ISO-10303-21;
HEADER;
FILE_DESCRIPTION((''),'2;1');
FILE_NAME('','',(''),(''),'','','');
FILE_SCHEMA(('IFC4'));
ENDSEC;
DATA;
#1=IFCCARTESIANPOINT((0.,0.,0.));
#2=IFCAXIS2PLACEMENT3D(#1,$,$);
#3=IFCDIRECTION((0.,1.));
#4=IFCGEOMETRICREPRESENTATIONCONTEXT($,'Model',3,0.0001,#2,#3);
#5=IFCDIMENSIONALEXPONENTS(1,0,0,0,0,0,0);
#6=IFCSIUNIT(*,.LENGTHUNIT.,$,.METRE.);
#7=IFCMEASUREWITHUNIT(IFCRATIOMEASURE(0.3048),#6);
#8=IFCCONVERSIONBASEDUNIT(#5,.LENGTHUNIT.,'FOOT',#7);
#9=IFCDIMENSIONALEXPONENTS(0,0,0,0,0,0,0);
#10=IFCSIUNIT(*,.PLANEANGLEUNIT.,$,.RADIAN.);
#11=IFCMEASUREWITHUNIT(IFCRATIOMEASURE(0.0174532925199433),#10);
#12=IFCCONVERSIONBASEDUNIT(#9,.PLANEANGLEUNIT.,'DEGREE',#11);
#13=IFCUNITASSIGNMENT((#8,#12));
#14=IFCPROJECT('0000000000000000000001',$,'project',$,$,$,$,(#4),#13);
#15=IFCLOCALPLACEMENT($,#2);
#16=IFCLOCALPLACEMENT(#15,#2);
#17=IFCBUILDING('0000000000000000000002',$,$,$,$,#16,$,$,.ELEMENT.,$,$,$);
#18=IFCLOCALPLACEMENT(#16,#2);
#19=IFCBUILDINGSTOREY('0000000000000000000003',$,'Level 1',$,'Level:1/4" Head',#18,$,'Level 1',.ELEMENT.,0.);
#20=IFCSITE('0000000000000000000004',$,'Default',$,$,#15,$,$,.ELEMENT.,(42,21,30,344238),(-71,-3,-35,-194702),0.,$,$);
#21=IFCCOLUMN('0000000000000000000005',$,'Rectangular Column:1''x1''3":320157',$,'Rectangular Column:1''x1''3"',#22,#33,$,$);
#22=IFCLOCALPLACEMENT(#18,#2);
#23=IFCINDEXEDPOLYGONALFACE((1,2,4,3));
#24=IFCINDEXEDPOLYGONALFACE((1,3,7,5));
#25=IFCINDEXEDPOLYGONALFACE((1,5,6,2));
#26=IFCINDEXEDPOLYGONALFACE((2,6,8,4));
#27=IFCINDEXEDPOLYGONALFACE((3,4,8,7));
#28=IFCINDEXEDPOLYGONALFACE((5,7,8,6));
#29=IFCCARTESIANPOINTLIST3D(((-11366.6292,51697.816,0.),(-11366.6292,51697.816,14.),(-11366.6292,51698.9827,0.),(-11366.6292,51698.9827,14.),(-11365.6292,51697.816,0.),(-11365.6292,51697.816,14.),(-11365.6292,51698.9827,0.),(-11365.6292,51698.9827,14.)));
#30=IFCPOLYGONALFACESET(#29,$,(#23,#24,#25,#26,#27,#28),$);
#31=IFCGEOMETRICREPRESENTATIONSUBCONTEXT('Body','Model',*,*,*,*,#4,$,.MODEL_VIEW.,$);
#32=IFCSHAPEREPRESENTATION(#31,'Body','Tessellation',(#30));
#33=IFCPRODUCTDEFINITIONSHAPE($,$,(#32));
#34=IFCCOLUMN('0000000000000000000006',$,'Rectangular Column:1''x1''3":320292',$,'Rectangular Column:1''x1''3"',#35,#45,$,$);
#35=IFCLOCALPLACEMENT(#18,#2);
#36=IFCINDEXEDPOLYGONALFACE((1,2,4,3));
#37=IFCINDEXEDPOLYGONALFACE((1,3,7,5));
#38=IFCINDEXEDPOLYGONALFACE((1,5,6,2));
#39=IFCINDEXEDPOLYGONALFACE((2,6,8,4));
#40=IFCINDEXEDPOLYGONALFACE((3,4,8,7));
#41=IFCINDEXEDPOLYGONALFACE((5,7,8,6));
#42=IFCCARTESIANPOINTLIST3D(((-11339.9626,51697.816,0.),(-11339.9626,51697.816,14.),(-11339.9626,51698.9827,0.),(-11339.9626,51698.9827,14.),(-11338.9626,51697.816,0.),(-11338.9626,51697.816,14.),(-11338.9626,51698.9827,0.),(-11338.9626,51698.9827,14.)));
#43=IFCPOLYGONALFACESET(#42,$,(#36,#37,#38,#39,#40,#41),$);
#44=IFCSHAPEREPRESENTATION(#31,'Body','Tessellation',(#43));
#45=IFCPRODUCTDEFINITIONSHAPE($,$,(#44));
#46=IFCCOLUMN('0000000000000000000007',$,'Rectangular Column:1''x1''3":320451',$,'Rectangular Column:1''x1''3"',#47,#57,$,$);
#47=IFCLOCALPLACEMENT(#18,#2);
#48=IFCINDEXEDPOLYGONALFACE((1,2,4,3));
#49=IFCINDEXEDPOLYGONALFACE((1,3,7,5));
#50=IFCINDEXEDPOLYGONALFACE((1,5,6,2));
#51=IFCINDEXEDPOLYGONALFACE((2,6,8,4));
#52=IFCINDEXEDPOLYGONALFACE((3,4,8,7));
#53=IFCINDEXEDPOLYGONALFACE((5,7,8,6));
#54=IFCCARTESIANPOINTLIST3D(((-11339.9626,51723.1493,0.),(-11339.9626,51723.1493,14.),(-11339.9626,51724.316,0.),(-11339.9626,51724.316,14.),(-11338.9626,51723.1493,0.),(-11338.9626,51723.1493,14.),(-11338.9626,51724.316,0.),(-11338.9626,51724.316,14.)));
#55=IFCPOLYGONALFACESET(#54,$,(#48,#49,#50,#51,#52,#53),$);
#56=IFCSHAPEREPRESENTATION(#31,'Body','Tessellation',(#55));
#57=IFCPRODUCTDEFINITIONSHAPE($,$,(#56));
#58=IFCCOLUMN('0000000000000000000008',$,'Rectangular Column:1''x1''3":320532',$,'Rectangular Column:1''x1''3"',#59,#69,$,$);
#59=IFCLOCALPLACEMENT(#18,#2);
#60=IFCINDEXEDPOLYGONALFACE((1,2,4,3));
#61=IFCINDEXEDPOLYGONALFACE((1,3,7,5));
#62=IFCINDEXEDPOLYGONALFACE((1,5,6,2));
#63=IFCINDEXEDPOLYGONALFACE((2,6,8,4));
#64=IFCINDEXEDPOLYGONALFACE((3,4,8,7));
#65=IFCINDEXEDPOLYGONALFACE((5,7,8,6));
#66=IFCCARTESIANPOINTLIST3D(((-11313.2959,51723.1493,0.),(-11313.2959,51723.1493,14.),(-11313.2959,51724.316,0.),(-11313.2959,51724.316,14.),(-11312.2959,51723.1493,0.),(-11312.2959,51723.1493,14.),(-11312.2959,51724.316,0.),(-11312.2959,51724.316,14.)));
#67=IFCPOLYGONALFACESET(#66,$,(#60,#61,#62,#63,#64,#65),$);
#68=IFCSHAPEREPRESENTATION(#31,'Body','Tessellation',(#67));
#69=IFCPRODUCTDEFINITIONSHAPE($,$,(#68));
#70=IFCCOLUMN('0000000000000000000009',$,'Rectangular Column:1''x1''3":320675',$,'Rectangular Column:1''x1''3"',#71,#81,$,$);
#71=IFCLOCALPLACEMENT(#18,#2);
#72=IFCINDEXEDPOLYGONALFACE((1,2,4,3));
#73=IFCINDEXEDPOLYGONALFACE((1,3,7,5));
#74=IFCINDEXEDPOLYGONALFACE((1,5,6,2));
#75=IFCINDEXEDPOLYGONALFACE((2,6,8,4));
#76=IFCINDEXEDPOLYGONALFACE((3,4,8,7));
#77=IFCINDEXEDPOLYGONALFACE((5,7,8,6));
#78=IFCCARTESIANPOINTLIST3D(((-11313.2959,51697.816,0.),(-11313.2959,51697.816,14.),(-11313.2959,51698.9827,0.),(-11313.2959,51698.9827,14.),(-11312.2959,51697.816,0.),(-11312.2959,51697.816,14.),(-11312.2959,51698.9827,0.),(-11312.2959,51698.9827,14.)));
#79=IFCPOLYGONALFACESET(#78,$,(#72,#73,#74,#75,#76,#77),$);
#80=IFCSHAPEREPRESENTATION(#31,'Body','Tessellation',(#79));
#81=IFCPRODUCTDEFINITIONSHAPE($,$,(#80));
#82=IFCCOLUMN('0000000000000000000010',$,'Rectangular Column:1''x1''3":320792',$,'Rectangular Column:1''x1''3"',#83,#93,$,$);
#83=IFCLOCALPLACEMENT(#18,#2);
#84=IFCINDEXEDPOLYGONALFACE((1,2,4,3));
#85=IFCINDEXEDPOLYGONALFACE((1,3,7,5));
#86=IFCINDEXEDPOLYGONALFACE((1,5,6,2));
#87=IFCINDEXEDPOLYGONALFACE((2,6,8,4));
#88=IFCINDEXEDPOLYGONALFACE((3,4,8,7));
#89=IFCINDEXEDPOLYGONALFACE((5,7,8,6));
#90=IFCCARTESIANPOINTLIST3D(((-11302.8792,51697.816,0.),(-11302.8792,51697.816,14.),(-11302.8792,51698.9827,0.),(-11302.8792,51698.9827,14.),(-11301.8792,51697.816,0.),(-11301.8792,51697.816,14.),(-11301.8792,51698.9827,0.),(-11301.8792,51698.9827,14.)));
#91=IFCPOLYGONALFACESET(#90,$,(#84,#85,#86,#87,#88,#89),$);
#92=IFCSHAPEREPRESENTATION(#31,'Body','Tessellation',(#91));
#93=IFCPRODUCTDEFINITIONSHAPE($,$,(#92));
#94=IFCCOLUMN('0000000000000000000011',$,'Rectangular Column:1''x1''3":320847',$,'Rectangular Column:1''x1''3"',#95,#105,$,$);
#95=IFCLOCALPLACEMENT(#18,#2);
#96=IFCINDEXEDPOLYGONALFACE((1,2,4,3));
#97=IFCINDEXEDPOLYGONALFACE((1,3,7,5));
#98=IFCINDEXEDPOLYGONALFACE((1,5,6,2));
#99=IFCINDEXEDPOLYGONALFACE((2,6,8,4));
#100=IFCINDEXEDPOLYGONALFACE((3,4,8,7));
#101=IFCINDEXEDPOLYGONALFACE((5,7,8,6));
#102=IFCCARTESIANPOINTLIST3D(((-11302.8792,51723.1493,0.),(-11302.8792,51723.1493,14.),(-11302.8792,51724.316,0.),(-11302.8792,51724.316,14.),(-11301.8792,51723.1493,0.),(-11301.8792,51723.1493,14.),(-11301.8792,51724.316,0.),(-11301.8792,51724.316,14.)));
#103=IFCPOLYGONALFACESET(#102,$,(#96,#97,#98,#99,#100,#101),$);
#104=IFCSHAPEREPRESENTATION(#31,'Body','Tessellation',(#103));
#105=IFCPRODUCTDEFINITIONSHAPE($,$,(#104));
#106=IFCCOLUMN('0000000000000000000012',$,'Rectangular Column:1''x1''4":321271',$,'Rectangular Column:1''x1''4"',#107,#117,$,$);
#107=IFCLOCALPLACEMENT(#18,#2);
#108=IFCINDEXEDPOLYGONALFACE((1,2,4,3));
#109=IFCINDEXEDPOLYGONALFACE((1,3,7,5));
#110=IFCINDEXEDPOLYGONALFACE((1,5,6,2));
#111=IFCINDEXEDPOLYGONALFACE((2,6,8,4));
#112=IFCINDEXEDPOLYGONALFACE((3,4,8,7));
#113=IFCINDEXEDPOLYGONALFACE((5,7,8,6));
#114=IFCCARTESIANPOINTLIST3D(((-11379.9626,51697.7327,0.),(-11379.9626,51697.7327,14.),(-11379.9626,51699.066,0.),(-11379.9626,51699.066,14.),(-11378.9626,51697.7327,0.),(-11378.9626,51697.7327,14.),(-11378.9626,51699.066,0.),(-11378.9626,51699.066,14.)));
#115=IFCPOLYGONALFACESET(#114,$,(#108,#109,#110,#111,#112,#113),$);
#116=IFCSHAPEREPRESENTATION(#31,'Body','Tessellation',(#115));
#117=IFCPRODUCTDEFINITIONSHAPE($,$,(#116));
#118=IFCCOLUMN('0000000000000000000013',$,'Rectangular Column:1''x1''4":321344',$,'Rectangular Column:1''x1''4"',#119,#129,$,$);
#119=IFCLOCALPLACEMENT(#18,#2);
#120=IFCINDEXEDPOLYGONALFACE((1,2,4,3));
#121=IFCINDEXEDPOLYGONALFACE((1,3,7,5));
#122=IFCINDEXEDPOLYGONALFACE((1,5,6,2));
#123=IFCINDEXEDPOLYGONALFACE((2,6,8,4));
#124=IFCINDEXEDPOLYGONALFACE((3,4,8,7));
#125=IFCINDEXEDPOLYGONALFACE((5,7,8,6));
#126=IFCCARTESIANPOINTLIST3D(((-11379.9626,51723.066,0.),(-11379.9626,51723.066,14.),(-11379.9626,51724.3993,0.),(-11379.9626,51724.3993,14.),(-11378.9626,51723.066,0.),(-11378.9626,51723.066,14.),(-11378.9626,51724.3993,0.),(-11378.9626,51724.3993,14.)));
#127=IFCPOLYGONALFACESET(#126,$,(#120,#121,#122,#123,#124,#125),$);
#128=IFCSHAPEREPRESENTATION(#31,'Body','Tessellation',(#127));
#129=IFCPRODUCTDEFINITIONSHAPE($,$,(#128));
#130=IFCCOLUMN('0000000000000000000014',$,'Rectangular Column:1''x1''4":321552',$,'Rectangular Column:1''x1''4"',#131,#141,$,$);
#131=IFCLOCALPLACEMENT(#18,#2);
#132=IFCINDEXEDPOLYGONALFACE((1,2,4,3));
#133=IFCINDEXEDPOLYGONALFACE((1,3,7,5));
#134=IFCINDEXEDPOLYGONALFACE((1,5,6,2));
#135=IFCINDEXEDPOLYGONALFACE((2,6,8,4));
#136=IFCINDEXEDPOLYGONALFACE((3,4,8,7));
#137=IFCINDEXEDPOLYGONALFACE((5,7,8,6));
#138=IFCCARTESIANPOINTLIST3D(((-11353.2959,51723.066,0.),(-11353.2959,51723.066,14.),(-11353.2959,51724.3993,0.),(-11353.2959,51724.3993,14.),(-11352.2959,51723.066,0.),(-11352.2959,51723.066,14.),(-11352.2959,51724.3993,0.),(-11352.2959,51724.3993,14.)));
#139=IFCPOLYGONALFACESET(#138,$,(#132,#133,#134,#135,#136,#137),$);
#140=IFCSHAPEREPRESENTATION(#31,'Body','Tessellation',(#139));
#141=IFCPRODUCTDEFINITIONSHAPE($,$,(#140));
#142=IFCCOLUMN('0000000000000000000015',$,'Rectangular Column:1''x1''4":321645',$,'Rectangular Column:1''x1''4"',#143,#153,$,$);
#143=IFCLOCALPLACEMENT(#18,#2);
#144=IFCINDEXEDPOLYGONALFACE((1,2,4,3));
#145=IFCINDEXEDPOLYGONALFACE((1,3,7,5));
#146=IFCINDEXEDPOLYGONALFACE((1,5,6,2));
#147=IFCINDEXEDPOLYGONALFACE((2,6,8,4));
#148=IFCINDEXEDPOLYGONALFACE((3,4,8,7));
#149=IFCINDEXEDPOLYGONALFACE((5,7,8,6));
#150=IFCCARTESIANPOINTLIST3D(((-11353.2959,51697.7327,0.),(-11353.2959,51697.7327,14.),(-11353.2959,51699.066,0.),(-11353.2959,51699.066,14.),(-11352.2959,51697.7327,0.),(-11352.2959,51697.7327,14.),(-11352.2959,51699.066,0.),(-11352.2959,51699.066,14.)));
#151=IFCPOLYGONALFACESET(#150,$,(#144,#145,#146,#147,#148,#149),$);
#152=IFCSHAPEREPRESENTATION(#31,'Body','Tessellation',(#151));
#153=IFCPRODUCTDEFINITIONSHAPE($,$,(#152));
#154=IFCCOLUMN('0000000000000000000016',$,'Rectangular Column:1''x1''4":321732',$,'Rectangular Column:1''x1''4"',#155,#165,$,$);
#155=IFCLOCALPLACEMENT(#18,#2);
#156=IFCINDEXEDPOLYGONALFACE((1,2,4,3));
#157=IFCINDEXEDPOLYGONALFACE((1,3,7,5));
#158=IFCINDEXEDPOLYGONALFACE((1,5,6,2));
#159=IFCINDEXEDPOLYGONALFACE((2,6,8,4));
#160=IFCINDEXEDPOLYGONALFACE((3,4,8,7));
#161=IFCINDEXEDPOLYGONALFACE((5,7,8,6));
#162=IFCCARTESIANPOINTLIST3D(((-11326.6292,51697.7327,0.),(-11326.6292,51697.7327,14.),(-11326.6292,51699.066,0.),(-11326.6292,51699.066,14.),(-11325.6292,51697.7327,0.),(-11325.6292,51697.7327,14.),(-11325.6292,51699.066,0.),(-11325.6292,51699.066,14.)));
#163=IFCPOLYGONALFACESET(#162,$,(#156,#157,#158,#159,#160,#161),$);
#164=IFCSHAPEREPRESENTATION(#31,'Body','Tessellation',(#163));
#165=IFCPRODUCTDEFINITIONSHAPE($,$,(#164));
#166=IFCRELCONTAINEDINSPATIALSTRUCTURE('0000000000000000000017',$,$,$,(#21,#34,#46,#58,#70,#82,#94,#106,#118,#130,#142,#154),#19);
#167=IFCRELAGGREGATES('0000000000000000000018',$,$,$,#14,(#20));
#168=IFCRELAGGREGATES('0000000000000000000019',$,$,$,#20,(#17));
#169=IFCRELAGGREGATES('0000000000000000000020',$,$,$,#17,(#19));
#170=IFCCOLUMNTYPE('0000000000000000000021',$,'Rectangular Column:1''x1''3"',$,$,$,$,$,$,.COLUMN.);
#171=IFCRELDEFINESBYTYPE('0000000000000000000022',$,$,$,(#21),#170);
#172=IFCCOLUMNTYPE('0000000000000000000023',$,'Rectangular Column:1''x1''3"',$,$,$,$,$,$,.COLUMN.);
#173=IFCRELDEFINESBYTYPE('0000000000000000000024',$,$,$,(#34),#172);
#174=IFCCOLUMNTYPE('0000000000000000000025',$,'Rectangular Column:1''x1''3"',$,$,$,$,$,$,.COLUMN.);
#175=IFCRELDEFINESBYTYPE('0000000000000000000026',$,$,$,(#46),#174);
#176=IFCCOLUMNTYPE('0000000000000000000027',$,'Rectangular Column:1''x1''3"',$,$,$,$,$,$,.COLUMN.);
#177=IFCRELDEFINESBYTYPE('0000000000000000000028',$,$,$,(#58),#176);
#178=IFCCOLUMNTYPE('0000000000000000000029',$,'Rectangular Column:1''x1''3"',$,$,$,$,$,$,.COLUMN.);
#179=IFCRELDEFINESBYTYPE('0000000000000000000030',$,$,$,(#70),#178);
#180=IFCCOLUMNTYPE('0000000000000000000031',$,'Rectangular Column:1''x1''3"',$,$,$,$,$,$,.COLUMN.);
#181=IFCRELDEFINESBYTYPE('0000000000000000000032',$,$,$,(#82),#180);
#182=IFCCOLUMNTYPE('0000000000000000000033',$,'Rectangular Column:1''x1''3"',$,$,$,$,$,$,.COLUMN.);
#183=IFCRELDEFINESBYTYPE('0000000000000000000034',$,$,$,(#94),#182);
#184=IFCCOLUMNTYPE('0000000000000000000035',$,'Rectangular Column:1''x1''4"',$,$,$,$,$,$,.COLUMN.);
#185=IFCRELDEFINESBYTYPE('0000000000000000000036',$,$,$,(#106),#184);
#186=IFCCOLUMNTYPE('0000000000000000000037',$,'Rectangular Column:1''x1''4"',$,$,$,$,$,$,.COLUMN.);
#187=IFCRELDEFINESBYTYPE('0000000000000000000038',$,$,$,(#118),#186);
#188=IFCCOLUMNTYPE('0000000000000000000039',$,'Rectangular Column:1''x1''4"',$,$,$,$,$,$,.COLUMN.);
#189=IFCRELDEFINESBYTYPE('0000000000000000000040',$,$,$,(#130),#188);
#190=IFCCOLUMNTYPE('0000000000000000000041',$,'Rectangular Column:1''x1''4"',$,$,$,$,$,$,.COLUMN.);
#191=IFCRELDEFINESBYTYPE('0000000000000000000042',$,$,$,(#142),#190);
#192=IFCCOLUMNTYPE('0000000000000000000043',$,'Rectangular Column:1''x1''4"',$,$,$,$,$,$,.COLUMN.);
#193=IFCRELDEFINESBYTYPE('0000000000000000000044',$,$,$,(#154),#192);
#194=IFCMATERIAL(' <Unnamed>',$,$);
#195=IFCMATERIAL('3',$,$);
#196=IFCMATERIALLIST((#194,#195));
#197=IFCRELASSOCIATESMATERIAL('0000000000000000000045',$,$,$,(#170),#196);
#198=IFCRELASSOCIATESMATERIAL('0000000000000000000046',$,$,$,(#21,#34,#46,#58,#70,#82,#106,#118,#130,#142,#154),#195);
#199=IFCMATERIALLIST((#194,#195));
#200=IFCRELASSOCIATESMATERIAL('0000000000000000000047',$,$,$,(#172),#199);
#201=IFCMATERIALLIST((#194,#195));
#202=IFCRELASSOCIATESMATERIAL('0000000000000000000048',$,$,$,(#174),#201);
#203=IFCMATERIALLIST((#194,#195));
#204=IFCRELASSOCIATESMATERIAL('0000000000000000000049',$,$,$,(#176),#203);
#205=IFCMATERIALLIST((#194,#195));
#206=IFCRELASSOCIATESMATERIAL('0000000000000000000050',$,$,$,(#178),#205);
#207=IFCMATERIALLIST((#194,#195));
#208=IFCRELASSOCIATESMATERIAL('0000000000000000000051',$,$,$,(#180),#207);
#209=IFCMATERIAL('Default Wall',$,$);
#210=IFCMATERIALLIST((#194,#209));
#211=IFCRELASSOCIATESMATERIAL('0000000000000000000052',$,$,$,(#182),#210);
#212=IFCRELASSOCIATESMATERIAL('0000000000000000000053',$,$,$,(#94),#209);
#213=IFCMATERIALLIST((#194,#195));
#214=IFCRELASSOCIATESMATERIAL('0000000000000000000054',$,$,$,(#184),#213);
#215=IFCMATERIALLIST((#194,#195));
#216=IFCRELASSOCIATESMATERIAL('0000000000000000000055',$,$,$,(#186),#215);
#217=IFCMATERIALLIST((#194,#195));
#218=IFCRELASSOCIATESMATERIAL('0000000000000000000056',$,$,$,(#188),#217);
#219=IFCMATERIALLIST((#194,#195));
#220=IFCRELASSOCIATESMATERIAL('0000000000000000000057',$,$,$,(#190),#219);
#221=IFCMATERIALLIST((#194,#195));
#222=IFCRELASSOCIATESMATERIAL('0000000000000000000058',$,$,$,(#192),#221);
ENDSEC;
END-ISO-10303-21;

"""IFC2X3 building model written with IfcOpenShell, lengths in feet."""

from ifc_helpers import new_model, entity, si_unit, converted_unit, direction, frame, frame_2d, origin, place, context, subcontext, project, spatial, rectangle, extrude, source, transform, mapped, material, material_list, type_object, type_shapes, element, save


model = new_model("IFC2X3")

# Units and contexts
model_context = context("Model", 3, precision=0.0001, world=origin(), true_north=direction((0.0, 1.0)))
body_context = subcontext(model_context, "Body", "Model", "MODEL_VIEW")
ifc_project = project(units=[converted_unit("LENGTHUNIT", "FOOT", entity("IfcRatioMeasure", 0.3048), si_unit("LENGTHUNIT", "METRE"), dimensions=[1, 0, 0, 0, 0, 0, 0]), converted_unit("PLANEANGLEUNIT", "DEGREE", entity("IfcRatioMeasure", 0.0174532925199433), si_unit("PLANEANGLEUNIT", "RADIAN"), dimensions=[0, 0, 0, 0, 0, 0, 0])], contexts=[model_context])

# Site, building, storey
site_placement = place(None, origin())
site = spatial("IfcSite", under=ifc_project, at=site_placement, Name="Default", CompositionType="ELEMENT", RefLatitude=(42, 21, 30, 344238), RefLongitude=(-71, -3, -35, -194702), RefElevation=0.0)
building_placement = place(site_placement, origin())
building = spatial("IfcBuilding", under=site, at=building_placement, CompositionType="ELEMENT")
storey_placement = place(building_placement, origin())
storey = spatial("IfcBuildingStorey", under=building, at=storey_placement, Name="Level 1", ObjectType="Level:1/4\" Head", LongName="Level 1", CompositionType="ELEMENT", Elevation=0.0)

# Columns
ifc_material_1 = material(Name="3")
ifc_material_2 = material(Name=" <Unnamed>")
ifc_material_list_1 = material_list([ifc_material_2, ifc_material_1])
column_type_1 = type_object("IfcColumnType", Name="Rectangular Column:1'x1'3\"", PredefinedType="COLUMN", material=ifc_material_list_1)
shared_shape_1 = source(origin(), body_context, "Body", "SweptSolid", [
    extrude(rectangle(XDim=1.1667, YDim=1.0, at=frame_2d((0.0, 0.0), x_axis=(1.0, 0.0))), frame((-11366.1292, 51698.3993, 0.0), z_axis=(0.0, 0.0, 1.0), x_axis=(0.0, -1.0, 0.0)), (0.0, 0.0, 1.0), 14.0),
])
type_shapes(column_type_1, [shared_shape_1])
column_1_placement = place(storey_placement, origin())
element("IfcColumn", 1, at=column_1_placement, inside=storey, type_object=column_type_1, material=ifc_material_1, Name="Rectangular Column:1'x1'3\":320157", ObjectType="Rectangular Column:1'x1'3\"", context=body_context, shape_type="MappedRepresentation", body=[
    mapped(shared_shape_1, transform((0.0, 0.0, 0.0), scale=1.0)),
])
ifc_material_list_2 = material_list([ifc_material_2, ifc_material_1])
column_type_2 = type_object("IfcColumnType", Name="Rectangular Column:1'x1'3\"", PredefinedType="COLUMN", material=ifc_material_list_2)
shared_shape_2 = source(origin(), body_context, "Body", "SweptSolid", [
    extrude(rectangle(XDim=1.1667, YDim=1.0, at=frame_2d((0.0, 0.0), x_axis=(1.0, 0.0))), frame((-11339.4626, 51698.3993, 0.0), z_axis=(0.0, 0.0, 1.0), x_axis=(0.0, -1.0, 0.0)), (0.0, 0.0, 1.0), 14.0),
])
type_shapes(column_type_2, [shared_shape_2])
column_2_placement = place(storey_placement, origin())
element("IfcColumn", 2, at=column_2_placement, inside=storey, type_object=column_type_2, material=ifc_material_1, Name="Rectangular Column:1'x1'3\":320292", ObjectType="Rectangular Column:1'x1'3\"", context=body_context, shape_type="MappedRepresentation", body=[
    mapped(shared_shape_2, transform((0.0, 0.0, 0.0), scale=1.0)),
])
ifc_material_list_3 = material_list([ifc_material_2, ifc_material_1])
column_type_3 = type_object("IfcColumnType", Name="Rectangular Column:1'x1'3\"", PredefinedType="COLUMN", material=ifc_material_list_3)
shared_shape_3 = source(origin(), body_context, "Body", "SweptSolid", [
    extrude(rectangle(XDim=1.1667, YDim=1.0, at=frame_2d((0.0, 0.0), x_axis=(1.0, 0.0))), frame((-11339.4626, 51723.7327, 0.0), z_axis=(0.0, 0.0, 1.0), x_axis=(0.0, -1.0, 0.0)), (0.0, 0.0, 1.0), 14.0),
])
type_shapes(column_type_3, [shared_shape_3])
column_3_placement = place(storey_placement, origin())
element("IfcColumn", 3, at=column_3_placement, inside=storey, type_object=column_type_3, material=ifc_material_1, Name="Rectangular Column:1'x1'3\":320451", ObjectType="Rectangular Column:1'x1'3\"", context=body_context, shape_type="MappedRepresentation", body=[
    mapped(shared_shape_3, transform((0.0, 0.0, 0.0), scale=1.0)),
])
ifc_material_list_4 = material_list([ifc_material_2, ifc_material_1])
column_type_4 = type_object("IfcColumnType", Name="Rectangular Column:1'x1'3\"", PredefinedType="COLUMN", material=ifc_material_list_4)
shared_shape_4 = source(origin(), body_context, "Body", "SweptSolid", [
    extrude(rectangle(XDim=1.1667, YDim=1.0, at=frame_2d((0.0, 0.0), x_axis=(1.0, 0.0))), frame((-11312.7959, 51723.7327, 0.0), z_axis=(0.0, 0.0, 1.0), x_axis=(0.0, -1.0, 0.0)), (0.0, 0.0, 1.0), 14.0),
])
type_shapes(column_type_4, [shared_shape_4])
column_4_placement = place(storey_placement, origin())
element("IfcColumn", 4, at=column_4_placement, inside=storey, type_object=column_type_4, material=ifc_material_1, Name="Rectangular Column:1'x1'3\":320532", ObjectType="Rectangular Column:1'x1'3\"", context=body_context, shape_type="MappedRepresentation", body=[
    mapped(shared_shape_4, transform((0.0, 0.0, 0.0), scale=1.0)),
])
ifc_material_list_5 = material_list([ifc_material_2, ifc_material_1])
column_type_5 = type_object("IfcColumnType", Name="Rectangular Column:1'x1'3\"", PredefinedType="COLUMN", material=ifc_material_list_5)
shared_shape_5 = source(origin(), body_context, "Body", "SweptSolid", [
    extrude(rectangle(XDim=1.1667, YDim=1.0, at=frame_2d((0.0, 0.0), x_axis=(1.0, 0.0))), frame((-11312.7959, 51698.3993, 0.0), z_axis=(0.0, 0.0, 1.0), x_axis=(0.0, -1.0, 0.0)), (0.0, 0.0, 1.0), 14.0),
])
type_shapes(column_type_5, [shared_shape_5])
column_5_placement = place(storey_placement, origin())
element("IfcColumn", 5, at=column_5_placement, inside=storey, type_object=column_type_5, material=ifc_material_1, Name="Rectangular Column:1'x1'3\":320675", ObjectType="Rectangular Column:1'x1'3\"", context=body_context, shape_type="MappedRepresentation", body=[
    mapped(shared_shape_5, transform((0.0, 0.0, 0.0), scale=1.0)),
])
ifc_material_list_6 = material_list([ifc_material_2, ifc_material_1])
column_type_6 = type_object("IfcColumnType", Name="Rectangular Column:1'x1'3\"", PredefinedType="COLUMN", material=ifc_material_list_6)
shared_shape_6 = source(origin(), body_context, "Body", "SweptSolid", [
    extrude(rectangle(XDim=1.1667, YDim=1.0, at=frame_2d((0.0, 0.0), x_axis=(1.0, 0.0))), frame((-11302.3792, 51698.3993, 0.0), z_axis=(0.0, 0.0, 1.0), x_axis=(0.0, -1.0, 0.0)), (0.0, 0.0, 1.0), 14.0),
])
type_shapes(column_type_6, [shared_shape_6])
column_6_placement = place(storey_placement, origin())
element("IfcColumn", 6, at=column_6_placement, inside=storey, type_object=column_type_6, material=ifc_material_1, Name="Rectangular Column:1'x1'3\":320792", ObjectType="Rectangular Column:1'x1'3\"", context=body_context, shape_type="MappedRepresentation", body=[
    mapped(shared_shape_6, transform((0.0, 0.0, 0.0), scale=1.0)),
])
ifc_material_3 = material(Name="Default Wall")
ifc_material_list_7 = material_list([ifc_material_2, ifc_material_3])
column_type_7 = type_object("IfcColumnType", Name="Rectangular Column:1'x1'3\"", PredefinedType="COLUMN", material=ifc_material_list_7)
shared_shape_7 = source(origin(), body_context, "Body", "SweptSolid", [
    extrude(rectangle(XDim=1.1667, YDim=1.0, at=frame_2d((0.0, 0.0), x_axis=(1.0, 0.0))), frame((-11302.3792, 51723.7327, 0.0), z_axis=(0.0, 0.0, 1.0), x_axis=(0.0, -1.0, 0.0)), (0.0, 0.0, 1.0), 14.0),
])
type_shapes(column_type_7, [shared_shape_7])
column_7_placement = place(storey_placement, origin())
element("IfcColumn", 7, at=column_7_placement, inside=storey, type_object=column_type_7, material=ifc_material_3, Name="Rectangular Column:1'x1'3\":320847", ObjectType="Rectangular Column:1'x1'3\"", context=body_context, shape_type="MappedRepresentation", body=[
    mapped(shared_shape_7, transform((0.0, 0.0, 0.0), scale=1.0)),
])
ifc_material_list_8 = material_list([ifc_material_2, ifc_material_1])
column_type_8 = type_object("IfcColumnType", Name="Rectangular Column:1'x1'4\"", PredefinedType="COLUMN", material=ifc_material_list_8)
shared_shape_8 = source(origin(), body_context, "Body", "SweptSolid", [
    extrude(rectangle(XDim=1.3333, YDim=1.0, at=frame_2d((0.0, 0.0), x_axis=(1.0, 0.0))), frame((-11379.4626, 51698.3993, 0.0), z_axis=(0.0, 0.0, 1.0), x_axis=(0.0, -1.0, 0.0)), (0.0, 0.0, 1.0), 14.0),
])
type_shapes(column_type_8, [shared_shape_8])
column_8_placement = place(storey_placement, origin())
element("IfcColumn", 8, at=column_8_placement, inside=storey, type_object=column_type_8, material=ifc_material_1, Name="Rectangular Column:1'x1'4\":321271", ObjectType="Rectangular Column:1'x1'4\"", context=body_context, shape_type="MappedRepresentation", body=[
    mapped(shared_shape_8, transform((0.0, 0.0, 0.0), scale=1.0)),
])
ifc_material_list_9 = material_list([ifc_material_2, ifc_material_1])
column_type_9 = type_object("IfcColumnType", Name="Rectangular Column:1'x1'4\"", PredefinedType="COLUMN", material=ifc_material_list_9)
shared_shape_9 = source(origin(), body_context, "Body", "SweptSolid", [
    extrude(rectangle(XDim=1.3333, YDim=1.0, at=frame_2d((0.0, 0.0), x_axis=(1.0, 0.0))), frame((-11379.4626, 51723.7327, 0.0), z_axis=(0.0, 0.0, 1.0), x_axis=(0.0, -1.0, 0.0)), (0.0, 0.0, 1.0), 14.0),
])
type_shapes(column_type_9, [shared_shape_9])
column_9_placement = place(storey_placement, origin())
element("IfcColumn", 9, at=column_9_placement, inside=storey, type_object=column_type_9, material=ifc_material_1, Name="Rectangular Column:1'x1'4\":321344", ObjectType="Rectangular Column:1'x1'4\"", context=body_context, shape_type="MappedRepresentation", body=[
    mapped(shared_shape_9, transform((0.0, 0.0, 0.0), scale=1.0)),
])
ifc_material_list_10 = material_list([ifc_material_2, ifc_material_1])
column_type_10 = type_object("IfcColumnType", Name="Rectangular Column:1'x1'4\"", PredefinedType="COLUMN", material=ifc_material_list_10)
shared_shape_10 = source(origin(), body_context, "Body", "SweptSolid", [
    extrude(rectangle(XDim=1.3333, YDim=1.0, at=frame_2d((0.0, 0.0), x_axis=(1.0, 0.0))), frame((-11352.7959, 51723.7327, 0.0), z_axis=(0.0, 0.0, 1.0), x_axis=(0.0, -1.0, 0.0)), (0.0, 0.0, 1.0), 14.0),
])
type_shapes(column_type_10, [shared_shape_10])
column_10_placement = place(storey_placement, origin())
element("IfcColumn", 10, at=column_10_placement, inside=storey, type_object=column_type_10, material=ifc_material_1, Name="Rectangular Column:1'x1'4\":321552", ObjectType="Rectangular Column:1'x1'4\"", context=body_context, shape_type="MappedRepresentation", body=[
    mapped(shared_shape_10, transform((0.0, 0.0, 0.0), scale=1.0)),
])
ifc_material_list_11 = material_list([ifc_material_2, ifc_material_1])
column_type_11 = type_object("IfcColumnType", Name="Rectangular Column:1'x1'4\"", PredefinedType="COLUMN", material=ifc_material_list_11)
shared_shape_11 = source(origin(), body_context, "Body", "SweptSolid", [
    extrude(rectangle(XDim=1.3333, YDim=1.0, at=frame_2d((0.0, 0.0), x_axis=(1.0, 0.0))), frame((-11352.7959, 51698.3993, 0.0), z_axis=(0.0, 0.0, 1.0), x_axis=(0.0, -1.0, 0.0)), (0.0, 0.0, 1.0), 14.0),
])
type_shapes(column_type_11, [shared_shape_11])
column_11_placement = place(storey_placement, origin())
element("IfcColumn", 11, at=column_11_placement, inside=storey, type_object=column_type_11, material=ifc_material_1, Name="Rectangular Column:1'x1'4\":321645", ObjectType="Rectangular Column:1'x1'4\"", context=body_context, shape_type="MappedRepresentation", body=[
    mapped(shared_shape_11, transform((0.0, 0.0, 0.0), scale=1.0)),
])
ifc_material_list_12 = material_list([ifc_material_2, ifc_material_1])
column_type_12 = type_object("IfcColumnType", Name="Rectangular Column:1'x1'4\"", PredefinedType="COLUMN", material=ifc_material_list_12)
shared_shape_12 = source(origin(), body_context, "Body", "SweptSolid", [
    extrude(rectangle(XDim=1.3333, YDim=1.0, at=frame_2d((0.0, 0.0), x_axis=(1.0, 0.0))), frame((-11326.1292, 51698.3993, 0.0), z_axis=(0.0, 0.0, 1.0), x_axis=(0.0, -1.0, 0.0)), (0.0, 0.0, 1.0), 14.0),
])
type_shapes(column_type_12, [shared_shape_12])
column_12_placement = place(storey_placement, origin())
element("IfcColumn", 12, at=column_12_placement, inside=storey, type_object=column_type_12, material=ifc_material_1, Name="Rectangular Column:1'x1'4\":321732", ObjectType="Rectangular Column:1'x1'4\"", context=body_context, shape_type="MappedRepresentation", body=[
    mapped(shared_shape_12, transform((0.0, 0.0, 0.0), scale=1.0)),
])

save(model, "model.ifc")
